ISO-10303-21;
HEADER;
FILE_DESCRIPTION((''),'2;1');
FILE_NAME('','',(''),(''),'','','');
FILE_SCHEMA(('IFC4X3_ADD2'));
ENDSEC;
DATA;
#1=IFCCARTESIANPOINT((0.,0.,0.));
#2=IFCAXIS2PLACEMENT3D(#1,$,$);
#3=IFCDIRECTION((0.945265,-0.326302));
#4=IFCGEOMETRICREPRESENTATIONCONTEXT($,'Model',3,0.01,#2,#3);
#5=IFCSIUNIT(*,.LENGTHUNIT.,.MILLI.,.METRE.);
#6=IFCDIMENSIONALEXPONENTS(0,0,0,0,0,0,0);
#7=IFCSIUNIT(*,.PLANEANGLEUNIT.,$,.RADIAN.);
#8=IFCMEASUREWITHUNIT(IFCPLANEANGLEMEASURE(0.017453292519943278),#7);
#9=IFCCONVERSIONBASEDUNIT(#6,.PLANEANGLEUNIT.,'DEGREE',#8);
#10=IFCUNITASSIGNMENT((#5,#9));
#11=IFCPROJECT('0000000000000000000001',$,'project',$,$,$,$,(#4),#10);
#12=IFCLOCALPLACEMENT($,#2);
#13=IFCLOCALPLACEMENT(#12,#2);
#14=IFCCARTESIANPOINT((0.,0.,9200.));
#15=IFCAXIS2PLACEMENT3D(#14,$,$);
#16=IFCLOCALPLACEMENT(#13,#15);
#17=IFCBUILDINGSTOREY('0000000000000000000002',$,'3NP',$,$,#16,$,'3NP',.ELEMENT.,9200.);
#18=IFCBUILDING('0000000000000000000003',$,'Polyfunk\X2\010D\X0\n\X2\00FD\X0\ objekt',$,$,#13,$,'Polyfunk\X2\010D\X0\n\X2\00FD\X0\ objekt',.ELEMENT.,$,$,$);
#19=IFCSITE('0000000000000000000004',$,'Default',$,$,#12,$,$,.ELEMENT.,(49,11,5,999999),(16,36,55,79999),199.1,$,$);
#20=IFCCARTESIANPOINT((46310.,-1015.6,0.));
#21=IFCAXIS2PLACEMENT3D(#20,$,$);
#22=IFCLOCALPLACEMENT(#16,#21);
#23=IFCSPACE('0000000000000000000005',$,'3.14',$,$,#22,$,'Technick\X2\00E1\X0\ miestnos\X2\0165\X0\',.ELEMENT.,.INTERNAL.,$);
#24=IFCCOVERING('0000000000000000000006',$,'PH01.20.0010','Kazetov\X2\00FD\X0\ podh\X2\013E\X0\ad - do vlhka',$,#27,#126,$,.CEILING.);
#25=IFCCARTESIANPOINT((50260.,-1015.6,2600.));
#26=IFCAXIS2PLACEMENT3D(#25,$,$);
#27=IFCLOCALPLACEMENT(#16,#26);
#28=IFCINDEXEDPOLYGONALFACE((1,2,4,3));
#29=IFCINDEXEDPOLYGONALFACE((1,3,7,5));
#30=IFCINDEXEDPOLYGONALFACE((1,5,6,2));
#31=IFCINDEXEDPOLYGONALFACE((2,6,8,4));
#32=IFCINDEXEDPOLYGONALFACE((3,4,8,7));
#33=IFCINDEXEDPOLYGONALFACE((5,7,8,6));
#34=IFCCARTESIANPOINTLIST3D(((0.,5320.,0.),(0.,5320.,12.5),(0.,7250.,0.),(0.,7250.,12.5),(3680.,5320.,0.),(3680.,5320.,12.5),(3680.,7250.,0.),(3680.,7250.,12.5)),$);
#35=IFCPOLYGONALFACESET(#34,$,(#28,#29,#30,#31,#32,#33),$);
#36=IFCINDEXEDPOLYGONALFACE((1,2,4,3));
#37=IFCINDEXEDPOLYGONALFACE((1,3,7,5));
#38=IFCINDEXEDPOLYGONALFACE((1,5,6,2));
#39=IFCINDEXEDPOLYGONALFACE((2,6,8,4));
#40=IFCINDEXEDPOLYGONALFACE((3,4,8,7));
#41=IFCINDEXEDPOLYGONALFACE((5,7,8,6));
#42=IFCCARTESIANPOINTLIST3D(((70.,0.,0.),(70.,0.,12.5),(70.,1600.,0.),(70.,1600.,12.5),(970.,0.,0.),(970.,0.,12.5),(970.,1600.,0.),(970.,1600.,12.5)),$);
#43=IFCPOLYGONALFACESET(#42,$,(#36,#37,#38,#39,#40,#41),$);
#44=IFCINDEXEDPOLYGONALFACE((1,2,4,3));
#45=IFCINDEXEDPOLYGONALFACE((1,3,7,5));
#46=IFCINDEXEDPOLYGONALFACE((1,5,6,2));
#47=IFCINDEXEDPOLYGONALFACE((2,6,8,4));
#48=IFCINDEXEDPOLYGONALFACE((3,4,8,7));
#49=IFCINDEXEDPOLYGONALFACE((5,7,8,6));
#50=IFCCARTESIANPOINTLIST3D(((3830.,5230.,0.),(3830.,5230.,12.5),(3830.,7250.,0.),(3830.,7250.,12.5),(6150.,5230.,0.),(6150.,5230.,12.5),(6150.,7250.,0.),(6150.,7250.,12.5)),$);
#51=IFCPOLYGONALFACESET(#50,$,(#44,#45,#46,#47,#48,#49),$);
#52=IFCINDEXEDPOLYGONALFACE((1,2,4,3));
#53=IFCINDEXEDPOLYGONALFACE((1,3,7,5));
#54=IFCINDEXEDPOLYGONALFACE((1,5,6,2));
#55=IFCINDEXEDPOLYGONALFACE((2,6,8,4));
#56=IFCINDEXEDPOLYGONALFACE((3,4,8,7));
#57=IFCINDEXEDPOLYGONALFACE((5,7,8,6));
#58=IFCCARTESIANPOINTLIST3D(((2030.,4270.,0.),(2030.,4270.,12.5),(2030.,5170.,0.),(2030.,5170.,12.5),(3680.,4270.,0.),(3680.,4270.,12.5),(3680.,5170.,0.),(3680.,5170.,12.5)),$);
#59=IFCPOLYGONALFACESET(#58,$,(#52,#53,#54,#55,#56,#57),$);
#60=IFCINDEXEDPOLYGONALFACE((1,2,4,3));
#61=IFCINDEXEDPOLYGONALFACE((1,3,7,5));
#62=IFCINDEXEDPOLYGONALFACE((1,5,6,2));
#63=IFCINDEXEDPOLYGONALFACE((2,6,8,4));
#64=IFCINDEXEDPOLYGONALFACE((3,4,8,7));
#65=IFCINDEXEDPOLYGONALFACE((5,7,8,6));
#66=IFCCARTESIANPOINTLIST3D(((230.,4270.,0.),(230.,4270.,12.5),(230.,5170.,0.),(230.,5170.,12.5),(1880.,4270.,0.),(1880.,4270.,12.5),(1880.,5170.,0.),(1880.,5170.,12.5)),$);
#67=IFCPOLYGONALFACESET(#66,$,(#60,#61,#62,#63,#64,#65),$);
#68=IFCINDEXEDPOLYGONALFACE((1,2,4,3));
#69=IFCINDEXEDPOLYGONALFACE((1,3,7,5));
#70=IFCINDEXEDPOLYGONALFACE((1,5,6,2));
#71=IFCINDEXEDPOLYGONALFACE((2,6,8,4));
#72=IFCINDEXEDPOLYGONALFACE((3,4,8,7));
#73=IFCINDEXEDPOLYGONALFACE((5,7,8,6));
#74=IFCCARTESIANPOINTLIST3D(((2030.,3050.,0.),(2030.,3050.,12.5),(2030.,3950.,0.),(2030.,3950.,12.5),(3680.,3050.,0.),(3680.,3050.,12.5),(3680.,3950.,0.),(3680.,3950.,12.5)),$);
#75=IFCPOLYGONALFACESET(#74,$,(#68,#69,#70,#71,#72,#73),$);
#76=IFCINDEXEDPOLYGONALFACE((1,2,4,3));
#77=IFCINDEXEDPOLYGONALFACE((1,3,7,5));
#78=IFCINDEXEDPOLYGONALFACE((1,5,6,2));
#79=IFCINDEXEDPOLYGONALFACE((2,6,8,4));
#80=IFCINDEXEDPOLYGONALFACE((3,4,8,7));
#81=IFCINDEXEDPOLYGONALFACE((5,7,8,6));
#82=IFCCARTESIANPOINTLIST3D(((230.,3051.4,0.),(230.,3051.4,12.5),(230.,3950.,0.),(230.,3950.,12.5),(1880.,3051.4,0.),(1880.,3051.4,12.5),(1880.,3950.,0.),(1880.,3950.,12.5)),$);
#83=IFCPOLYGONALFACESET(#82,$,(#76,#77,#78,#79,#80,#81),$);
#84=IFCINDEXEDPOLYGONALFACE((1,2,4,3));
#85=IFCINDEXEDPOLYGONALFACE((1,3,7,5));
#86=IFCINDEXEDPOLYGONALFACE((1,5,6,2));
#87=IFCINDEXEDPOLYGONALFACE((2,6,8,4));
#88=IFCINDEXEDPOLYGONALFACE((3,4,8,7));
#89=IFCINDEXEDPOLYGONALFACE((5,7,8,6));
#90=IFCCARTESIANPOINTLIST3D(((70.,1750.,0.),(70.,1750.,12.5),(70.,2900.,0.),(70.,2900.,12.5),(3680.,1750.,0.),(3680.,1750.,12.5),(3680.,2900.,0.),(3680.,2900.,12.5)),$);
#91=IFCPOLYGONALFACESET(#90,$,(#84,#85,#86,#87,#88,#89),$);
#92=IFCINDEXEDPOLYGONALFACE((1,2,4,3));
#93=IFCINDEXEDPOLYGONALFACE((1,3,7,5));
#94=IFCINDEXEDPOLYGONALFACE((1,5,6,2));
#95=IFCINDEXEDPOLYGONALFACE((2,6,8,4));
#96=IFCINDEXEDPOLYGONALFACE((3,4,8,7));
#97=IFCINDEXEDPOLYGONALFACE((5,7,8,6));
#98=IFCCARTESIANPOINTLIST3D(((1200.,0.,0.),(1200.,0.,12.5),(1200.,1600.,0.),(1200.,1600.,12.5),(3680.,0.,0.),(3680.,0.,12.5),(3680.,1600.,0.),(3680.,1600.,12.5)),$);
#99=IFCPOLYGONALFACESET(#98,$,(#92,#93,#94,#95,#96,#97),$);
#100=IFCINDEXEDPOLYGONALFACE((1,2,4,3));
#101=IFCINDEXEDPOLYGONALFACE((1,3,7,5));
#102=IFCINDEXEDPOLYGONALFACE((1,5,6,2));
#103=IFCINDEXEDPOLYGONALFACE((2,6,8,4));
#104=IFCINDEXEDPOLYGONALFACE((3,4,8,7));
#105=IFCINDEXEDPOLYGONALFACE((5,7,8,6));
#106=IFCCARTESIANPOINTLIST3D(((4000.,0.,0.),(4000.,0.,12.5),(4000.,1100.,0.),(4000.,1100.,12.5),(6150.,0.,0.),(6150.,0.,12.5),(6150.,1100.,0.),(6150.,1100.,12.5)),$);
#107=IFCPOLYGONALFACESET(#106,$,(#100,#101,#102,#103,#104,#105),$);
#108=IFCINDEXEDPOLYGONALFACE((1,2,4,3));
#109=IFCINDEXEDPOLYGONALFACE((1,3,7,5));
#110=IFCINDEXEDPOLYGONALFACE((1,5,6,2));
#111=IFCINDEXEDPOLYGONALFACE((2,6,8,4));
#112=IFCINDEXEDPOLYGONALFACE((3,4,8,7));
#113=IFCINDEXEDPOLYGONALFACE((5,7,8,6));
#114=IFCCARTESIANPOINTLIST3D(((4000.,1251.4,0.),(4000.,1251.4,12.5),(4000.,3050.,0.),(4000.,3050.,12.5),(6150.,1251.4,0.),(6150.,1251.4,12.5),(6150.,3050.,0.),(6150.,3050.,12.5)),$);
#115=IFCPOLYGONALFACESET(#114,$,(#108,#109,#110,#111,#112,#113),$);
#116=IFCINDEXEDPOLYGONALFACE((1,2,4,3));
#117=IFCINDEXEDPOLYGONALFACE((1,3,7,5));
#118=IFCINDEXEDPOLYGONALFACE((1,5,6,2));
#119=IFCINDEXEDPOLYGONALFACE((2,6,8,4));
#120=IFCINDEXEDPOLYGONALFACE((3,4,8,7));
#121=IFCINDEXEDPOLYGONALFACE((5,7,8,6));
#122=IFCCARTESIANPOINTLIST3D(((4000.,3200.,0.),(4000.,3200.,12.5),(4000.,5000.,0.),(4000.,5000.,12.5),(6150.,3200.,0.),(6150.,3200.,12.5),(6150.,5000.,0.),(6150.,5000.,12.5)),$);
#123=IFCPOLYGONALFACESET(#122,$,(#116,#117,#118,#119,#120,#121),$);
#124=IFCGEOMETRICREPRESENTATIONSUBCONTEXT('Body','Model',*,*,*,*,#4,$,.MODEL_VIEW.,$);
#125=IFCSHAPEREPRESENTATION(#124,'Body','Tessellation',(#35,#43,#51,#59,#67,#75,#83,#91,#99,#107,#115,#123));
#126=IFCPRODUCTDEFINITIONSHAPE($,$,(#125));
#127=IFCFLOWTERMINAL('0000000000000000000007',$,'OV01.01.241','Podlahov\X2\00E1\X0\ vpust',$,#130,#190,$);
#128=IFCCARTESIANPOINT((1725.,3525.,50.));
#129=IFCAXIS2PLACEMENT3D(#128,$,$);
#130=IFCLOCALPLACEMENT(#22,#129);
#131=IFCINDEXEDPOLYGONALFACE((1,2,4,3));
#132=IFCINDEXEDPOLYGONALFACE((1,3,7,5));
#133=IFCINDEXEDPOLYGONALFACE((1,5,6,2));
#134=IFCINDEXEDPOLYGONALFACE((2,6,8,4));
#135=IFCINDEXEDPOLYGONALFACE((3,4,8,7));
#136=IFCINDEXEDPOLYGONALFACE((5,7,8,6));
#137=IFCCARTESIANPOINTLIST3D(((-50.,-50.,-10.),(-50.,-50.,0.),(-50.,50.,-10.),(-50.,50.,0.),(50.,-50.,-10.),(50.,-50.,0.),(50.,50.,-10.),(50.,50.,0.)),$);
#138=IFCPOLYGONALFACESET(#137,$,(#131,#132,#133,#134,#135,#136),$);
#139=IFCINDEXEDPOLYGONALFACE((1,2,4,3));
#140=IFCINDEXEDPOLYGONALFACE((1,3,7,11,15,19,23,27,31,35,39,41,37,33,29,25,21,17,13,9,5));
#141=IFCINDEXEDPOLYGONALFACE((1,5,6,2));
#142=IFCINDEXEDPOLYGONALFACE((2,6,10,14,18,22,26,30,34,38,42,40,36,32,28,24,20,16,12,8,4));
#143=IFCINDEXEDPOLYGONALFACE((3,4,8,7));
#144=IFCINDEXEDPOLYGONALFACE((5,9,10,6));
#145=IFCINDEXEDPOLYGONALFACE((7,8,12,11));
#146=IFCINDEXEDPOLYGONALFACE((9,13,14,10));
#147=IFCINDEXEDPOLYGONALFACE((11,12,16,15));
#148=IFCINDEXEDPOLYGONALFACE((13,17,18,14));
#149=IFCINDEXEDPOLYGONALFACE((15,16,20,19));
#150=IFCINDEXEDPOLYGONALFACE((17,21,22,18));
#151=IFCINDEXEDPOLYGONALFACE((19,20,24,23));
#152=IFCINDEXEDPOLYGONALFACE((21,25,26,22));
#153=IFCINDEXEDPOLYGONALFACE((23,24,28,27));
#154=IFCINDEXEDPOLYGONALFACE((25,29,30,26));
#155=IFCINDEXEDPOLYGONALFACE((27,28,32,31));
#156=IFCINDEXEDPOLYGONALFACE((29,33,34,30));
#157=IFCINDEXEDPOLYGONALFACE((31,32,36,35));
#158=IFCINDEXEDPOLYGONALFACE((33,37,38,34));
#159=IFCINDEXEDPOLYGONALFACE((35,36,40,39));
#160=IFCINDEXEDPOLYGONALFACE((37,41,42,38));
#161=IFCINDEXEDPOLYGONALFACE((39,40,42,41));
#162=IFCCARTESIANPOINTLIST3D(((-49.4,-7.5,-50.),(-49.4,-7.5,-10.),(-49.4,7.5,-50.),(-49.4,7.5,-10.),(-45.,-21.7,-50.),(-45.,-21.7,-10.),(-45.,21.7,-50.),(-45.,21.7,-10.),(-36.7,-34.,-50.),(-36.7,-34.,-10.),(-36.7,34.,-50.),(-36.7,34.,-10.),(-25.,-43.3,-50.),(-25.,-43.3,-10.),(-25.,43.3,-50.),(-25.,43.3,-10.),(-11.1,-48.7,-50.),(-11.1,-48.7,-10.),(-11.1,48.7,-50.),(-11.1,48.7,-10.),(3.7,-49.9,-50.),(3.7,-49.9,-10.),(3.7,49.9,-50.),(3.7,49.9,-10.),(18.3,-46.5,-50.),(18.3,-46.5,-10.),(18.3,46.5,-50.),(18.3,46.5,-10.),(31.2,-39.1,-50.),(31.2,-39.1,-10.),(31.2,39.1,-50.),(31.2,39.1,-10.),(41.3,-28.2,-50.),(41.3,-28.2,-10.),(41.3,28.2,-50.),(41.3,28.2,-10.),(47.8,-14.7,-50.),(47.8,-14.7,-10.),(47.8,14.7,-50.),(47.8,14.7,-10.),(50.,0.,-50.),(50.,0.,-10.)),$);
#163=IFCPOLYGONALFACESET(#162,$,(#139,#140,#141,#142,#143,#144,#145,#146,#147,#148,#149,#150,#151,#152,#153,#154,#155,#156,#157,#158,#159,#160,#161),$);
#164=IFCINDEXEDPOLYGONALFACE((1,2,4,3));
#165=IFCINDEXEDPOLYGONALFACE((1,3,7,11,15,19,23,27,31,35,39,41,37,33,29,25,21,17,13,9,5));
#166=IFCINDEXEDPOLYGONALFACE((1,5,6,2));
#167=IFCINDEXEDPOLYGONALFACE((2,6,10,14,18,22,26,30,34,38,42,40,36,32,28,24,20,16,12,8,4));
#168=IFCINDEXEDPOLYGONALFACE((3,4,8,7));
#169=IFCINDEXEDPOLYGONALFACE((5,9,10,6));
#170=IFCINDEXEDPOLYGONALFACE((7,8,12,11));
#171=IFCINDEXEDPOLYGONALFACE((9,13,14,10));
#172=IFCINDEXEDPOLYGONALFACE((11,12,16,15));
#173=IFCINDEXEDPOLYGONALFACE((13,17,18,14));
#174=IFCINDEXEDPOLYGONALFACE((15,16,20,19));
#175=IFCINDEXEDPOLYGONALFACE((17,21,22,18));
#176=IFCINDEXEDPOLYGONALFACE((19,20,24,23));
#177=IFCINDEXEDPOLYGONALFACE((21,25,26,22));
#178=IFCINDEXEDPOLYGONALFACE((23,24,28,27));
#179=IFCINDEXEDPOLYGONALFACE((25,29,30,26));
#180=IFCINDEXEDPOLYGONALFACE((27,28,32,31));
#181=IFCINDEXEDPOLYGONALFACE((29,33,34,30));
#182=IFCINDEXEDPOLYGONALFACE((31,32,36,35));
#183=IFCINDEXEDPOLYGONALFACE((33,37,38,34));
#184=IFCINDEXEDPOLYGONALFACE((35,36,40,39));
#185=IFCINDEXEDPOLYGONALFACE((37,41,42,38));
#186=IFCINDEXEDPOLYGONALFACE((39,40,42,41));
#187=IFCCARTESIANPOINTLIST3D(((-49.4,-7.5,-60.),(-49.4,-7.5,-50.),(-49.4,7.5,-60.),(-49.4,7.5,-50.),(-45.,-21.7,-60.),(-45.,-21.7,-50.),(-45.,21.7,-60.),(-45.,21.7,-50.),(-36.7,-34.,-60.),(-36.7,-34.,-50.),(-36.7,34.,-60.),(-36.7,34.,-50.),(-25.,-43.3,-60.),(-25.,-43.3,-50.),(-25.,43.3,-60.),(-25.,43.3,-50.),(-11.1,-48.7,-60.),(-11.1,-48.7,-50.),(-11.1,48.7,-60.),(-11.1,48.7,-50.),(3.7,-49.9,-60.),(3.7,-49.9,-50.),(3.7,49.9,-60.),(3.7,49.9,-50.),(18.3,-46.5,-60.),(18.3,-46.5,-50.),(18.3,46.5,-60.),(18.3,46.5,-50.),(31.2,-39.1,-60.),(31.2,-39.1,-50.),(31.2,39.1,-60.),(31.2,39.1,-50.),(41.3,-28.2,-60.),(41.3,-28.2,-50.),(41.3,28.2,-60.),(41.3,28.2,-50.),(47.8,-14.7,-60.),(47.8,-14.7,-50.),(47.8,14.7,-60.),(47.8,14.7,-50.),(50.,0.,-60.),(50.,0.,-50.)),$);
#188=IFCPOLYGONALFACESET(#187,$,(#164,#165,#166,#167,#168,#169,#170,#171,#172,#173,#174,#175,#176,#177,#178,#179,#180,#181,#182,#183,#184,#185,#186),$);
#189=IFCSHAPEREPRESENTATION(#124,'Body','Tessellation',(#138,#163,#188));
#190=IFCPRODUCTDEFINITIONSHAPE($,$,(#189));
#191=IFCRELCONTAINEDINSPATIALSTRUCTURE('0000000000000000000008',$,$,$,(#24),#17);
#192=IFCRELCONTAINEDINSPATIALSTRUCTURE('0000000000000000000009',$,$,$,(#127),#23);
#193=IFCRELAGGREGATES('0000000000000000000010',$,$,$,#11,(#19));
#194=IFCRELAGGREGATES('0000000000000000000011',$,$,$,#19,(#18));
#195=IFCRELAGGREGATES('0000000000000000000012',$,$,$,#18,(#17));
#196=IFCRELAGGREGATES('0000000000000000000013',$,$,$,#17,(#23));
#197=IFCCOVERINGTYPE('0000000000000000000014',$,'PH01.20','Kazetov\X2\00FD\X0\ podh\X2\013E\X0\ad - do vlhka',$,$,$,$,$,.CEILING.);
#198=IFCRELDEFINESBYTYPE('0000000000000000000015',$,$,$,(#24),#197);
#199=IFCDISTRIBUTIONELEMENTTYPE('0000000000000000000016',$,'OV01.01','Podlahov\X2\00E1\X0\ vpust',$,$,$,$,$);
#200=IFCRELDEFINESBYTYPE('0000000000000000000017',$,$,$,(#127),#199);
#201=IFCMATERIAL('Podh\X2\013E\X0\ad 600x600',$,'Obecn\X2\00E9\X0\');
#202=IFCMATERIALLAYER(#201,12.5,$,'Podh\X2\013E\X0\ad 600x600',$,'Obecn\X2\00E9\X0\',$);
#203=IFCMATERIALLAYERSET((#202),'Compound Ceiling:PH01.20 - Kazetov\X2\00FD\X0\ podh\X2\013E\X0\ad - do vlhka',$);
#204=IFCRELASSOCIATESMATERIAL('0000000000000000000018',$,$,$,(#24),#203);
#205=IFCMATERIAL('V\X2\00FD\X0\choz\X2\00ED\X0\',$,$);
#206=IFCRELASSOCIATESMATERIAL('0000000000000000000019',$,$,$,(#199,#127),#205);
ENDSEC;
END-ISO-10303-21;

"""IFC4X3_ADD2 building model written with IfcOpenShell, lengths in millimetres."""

from ifc_helpers import new_model, entity, si_unit, converted_unit, direction, frame, frame_2d, origin, origin_2d_with_axis, place, context, subcontext, project, spatial, rectangle, circle, extrude, source, transform, mapped, material, layer, layer_set, layer_usage, type_object, type_shapes, element, save


model = new_model("IFC4X3_ADD2")

# Units and contexts
model_context = context("Model", 3, precision=0.01, world=origin(), true_north=direction((0.945265, -0.326302)))
body_context = subcontext(model_context, "Body", "Model", "MODEL_VIEW")
ifc_project = project(units=[si_unit("LENGTHUNIT", "METRE", prefix="MILLI"), converted_unit("PLANEANGLEUNIT", "DEGREE", entity("IfcPlaneAngleMeasure", 0.017453292519943278), si_unit("PLANEANGLEUNIT", "RADIAN"), dimensions=[0, 0, 0, 0, 0, 0, 0])], contexts=[model_context])

# Site, building, storey
site_placement = place(None, origin())
site = spatial("IfcSite", under=ifc_project, at=site_placement, Name="Default", CompositionType="ELEMENT", RefLatitude=(49, 11, 5, 999999), RefLongitude=(16, 36, 55, 79999), RefElevation=199.1)
building_placement = place(site_placement, origin())
building = spatial("IfcBuilding", under=site, at=building_placement, Name="Polyfunkčný objekt", LongName="Polyfunkčný objekt", CompositionType="ELEMENT")
storey_placement = place(building_placement, frame((0.0, 0.0, 9200.0)))
storey = spatial("IfcBuildingStorey", under=building, at=storey_placement, Name="3NP", LongName="3NP", CompositionType="ELEMENT", Elevation=9200.0)

# Covering
ifc_material_1 = material(Name="Podhľad 600x600", Category="Obecné")
ifc_layer_1 = layer(ifc_material_1, 12.5, Name="Podhľad 600x600", Category="Obecné")
ifc_layer_set_1 = layer_set([ifc_layer_1], Name="Compound Ceiling:PH01.20 - Kazetový podhľad - do vlhka")
ifc_layer_usage_1 = layer_usage(ifc_layer_set_1, "AXIS3", "NEGATIVE", 0.0)
covering_type = type_object("IfcCoveringType", Name="PH01.20", Description="Kazetový podhľad - do vlhka", PredefinedType="CEILING")
covering_placement = place(storey_placement, frame((50260.0, -1015.6, 2600.0)))
element("IfcCovering", 1, at=covering_placement, inside=storey, type_object=covering_type, material=ifc_layer_usage_1, Name="PH01.20.0010", Description="Kazetový podhľad - do vlhka", PredefinedType="CEILING", context=body_context, shape_type="SweptSolid", body=[
    extrude(rectangle(XDim=1930.0, YDim=3680.0, at=frame_2d((0.0, 0.0), x_axis=(1.0, 0.0))), frame((1840.0, 6285.0, 0.0), z_axis=(0.0, 0.0, 1.0), x_axis=(0.0, -1.0, 0.0)), (0.0, 0.0, 1.0), 12.5),
    extrude(rectangle(XDim=1600.0, YDim=900.0, at=origin_2d_with_axis()), frame((520.0, 800.0, 0.0), z_axis=(0.0, 0.0, 1.0), x_axis=(0.0, 1.0, 0.0)), (0.0, 0.0, 1.0), 12.5),
    extrude(rectangle(XDim=2320.0, YDim=2020.0, at=frame_2d((0.0, 0.0), x_axis=(1.0, 0.0))), frame((4990.0, 6240.0, 0.0), z_axis=(0.0, 0.0, 1.0), x_axis=(-1.0, 0.0, 0.0)), (0.0, 0.0, 1.0), 12.5),
    extrude(rectangle(XDim=900.0, YDim=1650.0, at=frame_2d((0.0, 0.0), x_axis=(1.0, 0.0))), frame((2855.0, 4720.0, 0.0), z_axis=(0.0, 0.0, 1.0), x_axis=(0.0, 1.0, 0.0)), (0.0, 0.0, 1.0), 12.5),
    extrude(rectangle(XDim=1650.0, YDim=900.0, at=frame_2d((0.0, 0.0), x_axis=(1.0, 0.0))), frame((1055.0, 4720.0, 0.0), z_axis=(0.0, 0.0, 1.0), x_axis=(-1.0, 0.0, 0.0)), (0.0, 0.0, 1.0), 12.5),
    extrude(rectangle(XDim=900.0, YDim=1650.0, at=frame_2d((0.0, 0.0), x_axis=(1.0, 0.0))), frame((2855.0, 3500.0, 0.0), z_axis=(0.0, 0.0, 1.0), x_axis=(0.0, -1.0, 0.0)), (0.0, 0.0, 1.0), 12.5),
    extrude(rectangle(XDim=1650.0, YDim=898.6, at=frame_2d((0.0, 0.0), x_axis=(1.0, 0.0))), frame((1055.0, 3500.7, 0.0), z_axis=(0.0, 0.0, 1.0), x_axis=(-1.0, 0.0, 0.0)), (0.0, 0.0, 1.0), 12.5),
    extrude(rectangle(XDim=3610.0, YDim=1150.0, at=frame_2d((0.0, 0.0), x_axis=(1.0, 0.0))), frame((1875.0, 2325.0, 0.0), z_axis=(0.0, 0.0, 1.0), x_axis=(-1.0, 0.0, 0.0)), (0.0, 0.0, 1.0), 12.5),
    extrude(rectangle(XDim=2480.0, YDim=1600.0, at=origin_2d_with_axis()), frame((2440.0, 800.0, 0.0), z_axis=(0.0, 0.0, 1.0), x_axis=(-1.0, 0.0, 0.0)), (0.0, 0.0, 1.0), 12.5),
    extrude(rectangle(XDim=1100.0, YDim=2150.0, at=frame_2d((0.0, 0.0), x_axis=(1.0, 0.0))), frame((5075.0, 550.0, 0.0), z_axis=(0.0, 0.0, 1.0), x_axis=(0.0, 1.0, 0.0)), (0.0, 0.0, 1.0), 12.5),
    extrude(rectangle(XDim=1798.6, YDim=2150.0, at=origin_2d_with_axis()), frame((5075.0, 2150.7, 0.0), z_axis=(0.0, 0.0, 1.0), x_axis=(0.0, 1.0, 0.0)), (0.0, 0.0, 1.0), 12.5),
    extrude(rectangle(XDim=1800.0, YDim=2150.0, at=frame_2d((0.0, 0.0), x_axis=(1.0, 0.0))), frame((5075.0, 4100.0, 0.0), z_axis=(0.0, 0.0, 1.0), x_axis=(0.0, 1.0, 0.0)), (0.0, 0.0, 1.0), 12.5),
])

# Shared definitions
space_placement = place(storey_placement, frame((46310.0, -1015.6, 0.0)))
space = spatial("IfcSpace", under=storey, at=space_placement, Name="3.14", LongName="Technická miestnosť", CompositionType="ELEMENT", PredefinedType="INTERNAL")

# Flow terminal
ifc_material_2 = material(Name="Výchozí")
distribution_element_type = type_object("IfcDistributionElementType", Name="OV01.01", Description="Podlahová vpust", material=ifc_material_2)
shared_shape_1 = source(origin(), body_context, "Body", "SweptSolid", [
    extrude(rectangle(XDim=100.0, YDim=100.0, at=frame_2d((0.0, 0.0), x_axis=(1.0, 0.0))), frame((0.0, 0.0, -10.0), z_axis=(0.0, 0.0, 1.0), x_axis=(-1.0, 0.0, 0.0)), (0.0, 0.0, 1.0), 10.0),
    extrude(circle(Radius=50.0, at=frame_2d((0.0, 0.0), x_axis=(1.0, 0.0))), frame((0.0, 0.0, -50.0)), (0.0, 0.0, 1.0), 40.0),
    extrude(circle(Radius=50.0, at=frame_2d((0.0, 0.0), x_axis=(1.0, 0.0))), frame((0.0, 0.0, -60.0)), (0.0, 0.0, 1.0), 10.0),
])
type_shapes(distribution_element_type, [shared_shape_1])
flow_terminal_placement = place(space_placement, frame((1725.0, 3525.0, 50.0)))
element("IfcFlowTerminal", 2, at=flow_terminal_placement, inside=space, type_object=distribution_element_type, material=ifc_material_2, Name="OV01.01.241", Description="Podlahová vpust", context=body_context, shape_type="MappedRepresentation", body=[
    mapped(shared_shape_1, transform((0.0, 0.0, 0.0), scale=1.0)),
])

save(model, "model.ifc")
